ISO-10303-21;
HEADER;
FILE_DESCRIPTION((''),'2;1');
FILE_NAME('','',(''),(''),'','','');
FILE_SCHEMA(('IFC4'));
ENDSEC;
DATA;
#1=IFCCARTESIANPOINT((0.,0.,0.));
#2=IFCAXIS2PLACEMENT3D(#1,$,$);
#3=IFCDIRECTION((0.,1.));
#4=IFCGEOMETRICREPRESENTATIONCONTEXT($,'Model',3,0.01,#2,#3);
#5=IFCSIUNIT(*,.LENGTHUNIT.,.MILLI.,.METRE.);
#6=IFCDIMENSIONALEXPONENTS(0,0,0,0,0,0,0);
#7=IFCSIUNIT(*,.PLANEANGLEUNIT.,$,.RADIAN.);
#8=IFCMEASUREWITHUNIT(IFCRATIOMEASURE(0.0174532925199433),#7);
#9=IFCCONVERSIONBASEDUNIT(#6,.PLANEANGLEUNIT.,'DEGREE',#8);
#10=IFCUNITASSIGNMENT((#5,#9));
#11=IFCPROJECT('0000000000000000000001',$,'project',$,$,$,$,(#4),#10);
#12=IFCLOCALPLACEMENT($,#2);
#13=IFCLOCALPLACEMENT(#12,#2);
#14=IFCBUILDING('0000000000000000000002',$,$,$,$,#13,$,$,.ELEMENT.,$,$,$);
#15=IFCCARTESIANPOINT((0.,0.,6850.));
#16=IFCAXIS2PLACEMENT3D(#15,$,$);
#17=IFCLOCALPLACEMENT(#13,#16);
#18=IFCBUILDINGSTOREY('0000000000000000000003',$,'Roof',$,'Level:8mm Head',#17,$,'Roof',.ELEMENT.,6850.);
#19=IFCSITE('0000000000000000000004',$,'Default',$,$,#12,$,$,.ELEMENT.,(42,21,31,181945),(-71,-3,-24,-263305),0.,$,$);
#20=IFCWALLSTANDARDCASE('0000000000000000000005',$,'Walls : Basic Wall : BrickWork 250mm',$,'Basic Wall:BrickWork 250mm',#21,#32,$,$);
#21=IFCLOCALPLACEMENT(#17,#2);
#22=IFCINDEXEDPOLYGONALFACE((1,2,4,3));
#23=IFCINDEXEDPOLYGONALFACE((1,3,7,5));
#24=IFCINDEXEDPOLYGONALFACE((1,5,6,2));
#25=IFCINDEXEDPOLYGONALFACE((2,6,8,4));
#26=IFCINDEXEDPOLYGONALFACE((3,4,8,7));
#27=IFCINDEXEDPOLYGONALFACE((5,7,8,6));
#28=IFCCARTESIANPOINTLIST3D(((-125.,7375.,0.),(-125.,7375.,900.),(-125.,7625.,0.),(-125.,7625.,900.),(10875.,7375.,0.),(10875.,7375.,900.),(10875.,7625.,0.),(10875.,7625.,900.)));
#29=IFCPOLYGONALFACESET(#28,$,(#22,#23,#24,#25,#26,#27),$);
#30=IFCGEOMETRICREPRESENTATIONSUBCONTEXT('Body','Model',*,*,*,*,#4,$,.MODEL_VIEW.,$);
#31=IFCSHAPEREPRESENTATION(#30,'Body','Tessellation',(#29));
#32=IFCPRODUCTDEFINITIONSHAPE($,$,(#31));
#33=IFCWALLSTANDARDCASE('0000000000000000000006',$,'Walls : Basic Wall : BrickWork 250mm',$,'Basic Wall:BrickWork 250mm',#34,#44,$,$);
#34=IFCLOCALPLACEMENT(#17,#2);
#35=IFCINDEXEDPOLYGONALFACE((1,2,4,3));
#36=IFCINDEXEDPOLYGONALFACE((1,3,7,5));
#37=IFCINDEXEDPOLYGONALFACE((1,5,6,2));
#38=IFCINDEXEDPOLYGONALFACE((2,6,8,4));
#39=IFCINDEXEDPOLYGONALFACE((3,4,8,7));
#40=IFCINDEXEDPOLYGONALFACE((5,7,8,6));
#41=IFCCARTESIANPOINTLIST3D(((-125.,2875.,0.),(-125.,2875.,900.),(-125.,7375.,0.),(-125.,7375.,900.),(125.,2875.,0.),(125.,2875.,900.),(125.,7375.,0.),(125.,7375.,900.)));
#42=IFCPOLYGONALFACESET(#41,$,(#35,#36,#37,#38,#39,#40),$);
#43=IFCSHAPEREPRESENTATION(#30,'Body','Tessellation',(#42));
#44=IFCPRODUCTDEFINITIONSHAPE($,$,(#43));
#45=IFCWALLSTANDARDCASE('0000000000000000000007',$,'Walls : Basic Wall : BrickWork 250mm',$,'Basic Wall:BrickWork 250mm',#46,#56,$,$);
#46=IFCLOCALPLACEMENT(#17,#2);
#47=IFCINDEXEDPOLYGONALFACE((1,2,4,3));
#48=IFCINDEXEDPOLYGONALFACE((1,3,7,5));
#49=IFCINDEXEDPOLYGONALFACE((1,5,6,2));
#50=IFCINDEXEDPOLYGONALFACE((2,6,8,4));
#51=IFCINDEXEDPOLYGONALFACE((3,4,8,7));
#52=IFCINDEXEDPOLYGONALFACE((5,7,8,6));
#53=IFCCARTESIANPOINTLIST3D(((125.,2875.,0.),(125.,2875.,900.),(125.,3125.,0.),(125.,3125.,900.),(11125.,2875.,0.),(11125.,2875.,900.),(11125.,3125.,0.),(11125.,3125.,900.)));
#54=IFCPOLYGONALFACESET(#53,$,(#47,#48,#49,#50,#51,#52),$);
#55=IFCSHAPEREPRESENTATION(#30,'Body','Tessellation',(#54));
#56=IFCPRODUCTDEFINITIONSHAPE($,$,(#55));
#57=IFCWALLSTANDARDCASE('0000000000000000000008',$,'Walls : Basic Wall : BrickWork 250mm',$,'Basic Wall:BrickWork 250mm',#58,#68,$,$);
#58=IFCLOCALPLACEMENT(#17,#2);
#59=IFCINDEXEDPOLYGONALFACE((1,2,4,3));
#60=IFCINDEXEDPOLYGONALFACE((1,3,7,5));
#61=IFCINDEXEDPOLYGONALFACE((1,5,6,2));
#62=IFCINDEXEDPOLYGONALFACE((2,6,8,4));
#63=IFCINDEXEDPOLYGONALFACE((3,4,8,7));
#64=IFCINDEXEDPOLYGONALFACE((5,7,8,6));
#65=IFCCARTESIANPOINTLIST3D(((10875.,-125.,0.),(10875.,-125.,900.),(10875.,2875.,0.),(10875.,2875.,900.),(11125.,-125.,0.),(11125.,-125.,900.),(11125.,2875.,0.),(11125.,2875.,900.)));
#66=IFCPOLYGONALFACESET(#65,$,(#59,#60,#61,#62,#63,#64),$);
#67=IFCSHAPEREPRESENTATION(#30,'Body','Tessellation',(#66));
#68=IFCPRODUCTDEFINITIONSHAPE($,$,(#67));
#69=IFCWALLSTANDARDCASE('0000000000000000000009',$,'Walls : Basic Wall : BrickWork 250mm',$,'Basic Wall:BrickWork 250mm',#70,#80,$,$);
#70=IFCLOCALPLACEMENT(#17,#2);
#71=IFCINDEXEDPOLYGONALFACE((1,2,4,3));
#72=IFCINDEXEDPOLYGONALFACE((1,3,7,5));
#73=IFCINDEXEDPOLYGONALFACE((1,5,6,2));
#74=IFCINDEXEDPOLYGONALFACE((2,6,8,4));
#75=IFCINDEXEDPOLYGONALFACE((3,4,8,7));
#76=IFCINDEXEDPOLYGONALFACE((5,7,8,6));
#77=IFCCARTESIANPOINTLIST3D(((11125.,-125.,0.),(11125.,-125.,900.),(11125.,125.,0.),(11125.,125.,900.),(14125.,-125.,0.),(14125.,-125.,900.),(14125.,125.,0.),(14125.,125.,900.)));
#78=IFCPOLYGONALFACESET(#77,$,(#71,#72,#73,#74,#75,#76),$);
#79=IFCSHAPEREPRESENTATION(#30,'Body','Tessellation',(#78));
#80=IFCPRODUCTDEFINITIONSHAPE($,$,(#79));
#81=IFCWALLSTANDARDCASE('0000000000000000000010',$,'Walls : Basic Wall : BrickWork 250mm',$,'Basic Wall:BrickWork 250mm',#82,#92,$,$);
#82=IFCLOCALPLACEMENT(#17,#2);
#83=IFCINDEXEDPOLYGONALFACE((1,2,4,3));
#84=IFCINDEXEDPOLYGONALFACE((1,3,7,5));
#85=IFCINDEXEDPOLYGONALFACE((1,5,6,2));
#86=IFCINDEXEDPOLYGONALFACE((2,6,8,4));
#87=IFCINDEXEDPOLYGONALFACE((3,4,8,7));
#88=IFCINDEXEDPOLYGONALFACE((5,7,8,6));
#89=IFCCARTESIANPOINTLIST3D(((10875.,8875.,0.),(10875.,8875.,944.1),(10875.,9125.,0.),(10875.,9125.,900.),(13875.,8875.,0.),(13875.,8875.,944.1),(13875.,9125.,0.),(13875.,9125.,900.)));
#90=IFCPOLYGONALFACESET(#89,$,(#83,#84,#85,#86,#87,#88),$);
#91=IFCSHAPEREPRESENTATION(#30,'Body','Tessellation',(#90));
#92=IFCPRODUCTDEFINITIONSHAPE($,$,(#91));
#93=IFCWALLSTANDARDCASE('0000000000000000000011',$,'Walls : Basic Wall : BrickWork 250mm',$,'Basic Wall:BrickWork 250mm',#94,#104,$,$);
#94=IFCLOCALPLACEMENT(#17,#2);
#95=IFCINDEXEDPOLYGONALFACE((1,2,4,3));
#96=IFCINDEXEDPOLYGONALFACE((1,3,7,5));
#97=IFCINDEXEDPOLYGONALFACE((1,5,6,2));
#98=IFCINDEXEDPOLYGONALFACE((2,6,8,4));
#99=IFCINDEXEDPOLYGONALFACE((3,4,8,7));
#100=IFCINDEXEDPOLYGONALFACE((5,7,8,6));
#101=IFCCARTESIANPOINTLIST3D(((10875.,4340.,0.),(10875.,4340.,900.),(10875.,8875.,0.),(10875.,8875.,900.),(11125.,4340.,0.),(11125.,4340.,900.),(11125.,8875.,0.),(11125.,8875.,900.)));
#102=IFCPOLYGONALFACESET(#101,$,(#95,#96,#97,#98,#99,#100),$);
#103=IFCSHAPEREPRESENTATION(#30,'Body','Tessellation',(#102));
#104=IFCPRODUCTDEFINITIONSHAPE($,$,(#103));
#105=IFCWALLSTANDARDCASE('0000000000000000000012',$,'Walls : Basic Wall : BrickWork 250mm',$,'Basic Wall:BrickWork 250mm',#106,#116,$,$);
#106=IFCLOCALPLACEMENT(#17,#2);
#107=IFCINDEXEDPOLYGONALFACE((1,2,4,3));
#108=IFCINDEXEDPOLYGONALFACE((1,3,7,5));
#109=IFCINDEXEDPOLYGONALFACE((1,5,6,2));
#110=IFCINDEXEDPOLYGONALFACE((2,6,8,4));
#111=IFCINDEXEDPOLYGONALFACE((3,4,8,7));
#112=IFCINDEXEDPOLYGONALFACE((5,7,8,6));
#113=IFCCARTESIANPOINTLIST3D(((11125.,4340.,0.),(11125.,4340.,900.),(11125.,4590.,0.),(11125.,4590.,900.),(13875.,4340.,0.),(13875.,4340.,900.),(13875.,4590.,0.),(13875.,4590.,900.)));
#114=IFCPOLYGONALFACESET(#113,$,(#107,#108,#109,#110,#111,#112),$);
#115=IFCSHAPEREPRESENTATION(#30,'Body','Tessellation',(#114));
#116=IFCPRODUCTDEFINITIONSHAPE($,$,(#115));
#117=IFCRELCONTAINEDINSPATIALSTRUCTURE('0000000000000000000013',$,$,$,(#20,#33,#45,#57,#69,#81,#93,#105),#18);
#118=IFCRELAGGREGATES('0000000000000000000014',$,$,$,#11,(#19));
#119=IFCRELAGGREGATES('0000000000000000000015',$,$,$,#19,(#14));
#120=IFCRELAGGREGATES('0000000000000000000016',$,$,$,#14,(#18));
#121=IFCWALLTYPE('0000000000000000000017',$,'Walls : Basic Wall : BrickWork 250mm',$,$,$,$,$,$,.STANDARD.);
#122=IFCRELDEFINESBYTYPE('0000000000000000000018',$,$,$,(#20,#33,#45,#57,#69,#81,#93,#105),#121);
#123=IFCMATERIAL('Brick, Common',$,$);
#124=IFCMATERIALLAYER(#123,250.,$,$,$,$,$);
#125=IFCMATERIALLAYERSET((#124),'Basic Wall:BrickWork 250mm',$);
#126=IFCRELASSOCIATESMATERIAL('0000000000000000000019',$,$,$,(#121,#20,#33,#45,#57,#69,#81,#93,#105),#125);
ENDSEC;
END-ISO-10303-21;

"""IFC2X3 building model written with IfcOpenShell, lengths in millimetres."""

from ifc_helpers import new_model, entity, si_unit, converted_unit, direction, frame, frame_2d, origin, place, context, subcontext, project, spatial, polyline, rectangle, extrude, clip, halfspace, bounded_halfspace, material, layer, layer_set, layer_usage, type_object, element, save


model = new_model("IFC2X3")

# Units and contexts
model_context = context("Model", 3, precision=0.01, world=origin(), true_north=direction((0.0, 1.0)))
body_context = subcontext(model_context, "Body", "Model", "MODEL_VIEW")
ifc_project = project(units=[si_unit("LENGTHUNIT", "METRE", prefix="MILLI"), converted_unit("PLANEANGLEUNIT", "DEGREE", entity("IfcRatioMeasure", 0.0174532925199433), si_unit("PLANEANGLEUNIT", "RADIAN"), dimensions=[0, 0, 0, 0, 0, 0, 0])], contexts=[model_context])

# Site, building, storey
site_placement = place(None, origin())
site = spatial("IfcSite", under=ifc_project, at=site_placement, Name="Default", CompositionType="ELEMENT", RefLatitude=(42, 21, 31, 181945), RefLongitude=(-71, -3, -24, -263305), RefElevation=0.0)
building_placement = place(site_placement, origin())
building = spatial("IfcBuilding", under=site, at=building_placement, CompositionType="ELEMENT")
storey_placement = place(building_placement, frame((0.0, 0.0, 6850.0)))
storey = spatial("IfcBuildingStorey", under=building, at=storey_placement, Name="Roof", ObjectType="Level:8mm Head", LongName="Roof", CompositionType="ELEMENT", Elevation=6850.0)

# Walls
ifc_material = material(Name="Brick, Common")
ifc_layer = layer(ifc_material, 250.0)
ifc_layer_set = layer_set([ifc_layer], Name="Basic Wall:BrickWork 250mm")
ifc_layer_usage_1 = layer_usage(ifc_layer_set, "AXIS2", "POSITIVE", -125.0)
wall_type = type_object("IfcWallType", Name="Walls : Basic Wall : BrickWork 250mm", PredefinedType="STANDARD", material=ifc_layer_set)
wall_1_placement = place(storey_placement, frame((-125.0, 7500.0, 0.0)))
element("IfcWallStandardCase", 1, at=wall_1_placement, inside=storey, type_object=wall_type, material=ifc_layer_usage_1, Name="Walls : Basic Wall : BrickWork 250mm", ObjectType="Basic Wall:BrickWork 250mm", context=body_context, shape_type="Clipping", body=[
    clip(extrude(rectangle(XDim=11000.0, YDim=250.0, at=frame_2d((5500.0, 0.0), x_axis=(-1.0, 0.0))), origin(), (0.0, 0.0, 1.0), 900.0), halfspace(frame((0.0, 0.0, -6400.0)), True)),
])
ifc_layer_usage_2 = layer_usage(ifc_layer_set, "AXIS2", "POSITIVE", -125.0)
wall_2_placement = place(storey_placement, frame((0.0, 7375.0, 0.0), z_axis=(0.0, 0.0, 1.0), x_axis=(0.0, -1.0, 0.0)))
element("IfcWallStandardCase", 2, at=wall_2_placement, inside=storey, type_object=wall_type, material=ifc_layer_usage_2, Name="Walls : Basic Wall : BrickWork 250mm", ObjectType="Basic Wall:BrickWork 250mm", context=body_context, shape_type="Clipping", body=[
    clip(extrude(rectangle(XDim=4500.0, YDim=250.0, at=frame_2d((2250.0, 0.0), x_axis=(-1.0, 0.0))), origin(), (0.0, 0.0, 1.0), 900.0), halfspace(frame((0.0, 0.0, -6400.0)), True)),
])
ifc_layer_usage_3 = layer_usage(ifc_layer_set, "AXIS2", "POSITIVE", -125.0)
wall_3_placement = place(storey_placement, frame((125.0, 3000.0, 0.0)))
element("IfcWallStandardCase", 3, at=wall_3_placement, inside=storey, type_object=wall_type, material=ifc_layer_usage_3, Name="Walls : Basic Wall : BrickWork 250mm", ObjectType="Basic Wall:BrickWork 250mm", context=body_context, shape_type="Clipping", body=[
    clip(extrude(rectangle(XDim=11000.0, YDim=250.0, at=frame_2d((5500.0, 0.0), x_axis=(-1.0, 0.0))), origin(), (0.0, 0.0, 1.0), 900.0), halfspace(frame((0.0, 0.0, -6400.0)), True)),
])
ifc_layer_usage_4 = layer_usage(ifc_layer_set, "AXIS2", "POSITIVE", -125.0)
wall_4_placement = place(storey_placement, frame((11000.0, 2875.0, 0.0), z_axis=(0.0, 0.0, 1.0), x_axis=(0.0, -1.0, 0.0)))
element("IfcWallStandardCase", 4, at=wall_4_placement, inside=storey, type_object=wall_type, material=ifc_layer_usage_4, Name="Walls : Basic Wall : BrickWork 250mm", ObjectType="Basic Wall:BrickWork 250mm", context=body_context, shape_type="Clipping", body=[
    clip(extrude(rectangle(XDim=3000.0, YDim=250.0, at=frame_2d((1500.0, 0.0), x_axis=(-1.0, 0.0))), origin(), (0.0, 0.0, 1.0), 900.0), halfspace(frame((0.0, 0.0, -6400.0)), True)),
])
ifc_layer_usage_5 = layer_usage(ifc_layer_set, "AXIS2", "POSITIVE", -125.0)
wall_5_placement = place(storey_placement, frame((11125.0, 0.0, 0.0)))
element("IfcWallStandardCase", 5, at=wall_5_placement, inside=storey, type_object=wall_type, material=ifc_layer_usage_5, Name="Walls : Basic Wall : BrickWork 250mm", ObjectType="Basic Wall:BrickWork 250mm", context=body_context, shape_type="Clipping", body=[
    clip(extrude(rectangle(XDim=3000.0, YDim=250.0, at=frame_2d((1500.0, 0.0), x_axis=(-1.0, 0.0))), origin(), (0.0, 0.0, 1.0), 900.0), halfspace(frame((0.0, 0.0, -6400.0)), True)),
])
ifc_layer_usage_6 = layer_usage(ifc_layer_set, "AXIS2", "POSITIVE", -125.0)
wall_6_placement = place(storey_placement, frame((13875.0, 9000.0, 0.0), z_axis=(0.0, 0.0, 1.0), x_axis=(-1.0, 0.0, 0.0)))
element("IfcWallStandardCase", 6, at=wall_6_placement, inside=storey, type_object=wall_type, material=ifc_layer_usage_6, Name="Walls : Basic Wall : BrickWork 250mm", ObjectType="Basic Wall:BrickWork 250mm", context=body_context, shape_type="Clipping", body=[
    clip(clip(extrude(rectangle(XDim=3000.0, YDim=250.0, at=frame_2d((1500.0, 0.0), x_axis=(-1.0, 0.0))), origin(), (0.0, 0.0, 1.0), 944.1), bounded_halfspace(frame((0.0, -125.0, 900.0), z_axis=(0.0, -0.173648, 0.984808), x_axis=(1.0, 0.0, 0.0)), False, frame((0.0, -125.0, 900.0)), polyline([(0.0, 0.0), (3000.0, 0.0), (3000.0, 250.0), (2750.0, 250.0), (0.0, 250.0), (0.0, 0.0)]))), halfspace(frame((0.0, 0.0, -6400.0)), True)),
])
ifc_layer_usage_7 = layer_usage(ifc_layer_set, "AXIS2", "POSITIVE", -125.0)
wall_7_placement = place(storey_placement, frame((11000.0, 8875.0, 0.0), z_axis=(0.0, 0.0, 1.0), x_axis=(0.0, -1.0, 0.0)))
element("IfcWallStandardCase", 7, at=wall_7_placement, inside=storey, type_object=wall_type, material=ifc_layer_usage_7, Name="Walls : Basic Wall : BrickWork 250mm", ObjectType="Basic Wall:BrickWork 250mm", context=body_context, shape_type="Clipping", body=[
    clip(extrude(rectangle(XDim=4535.0, YDim=250.0, at=frame_2d((2267.5, 0.0), x_axis=(-1.0, 0.0))), origin(), (0.0, 0.0, 1.0), 900.0), halfspace(origin(), True)),
])
ifc_layer_usage_8 = layer_usage(ifc_layer_set, "AXIS2", "POSITIVE", -125.0)
wall_8_placement = place(storey_placement, frame((11125.0, 4465.0, 0.0)))
element("IfcWallStandardCase", 8, at=wall_8_placement, inside=storey, type_object=wall_type, material=ifc_layer_usage_8, Name="Walls : Basic Wall : BrickWork 250mm", ObjectType="Basic Wall:BrickWork 250mm", context=body_context, shape_type="Clipping", body=[
    clip(extrude(rectangle(XDim=2750.0, YDim=250.0, at=frame_2d((1375.0, 0.0), x_axis=(-1.0, 0.0))), origin(), (0.0, 0.0, 1.0), 900.0), halfspace(origin(), True)),
])

save(model, "model.ifc")
